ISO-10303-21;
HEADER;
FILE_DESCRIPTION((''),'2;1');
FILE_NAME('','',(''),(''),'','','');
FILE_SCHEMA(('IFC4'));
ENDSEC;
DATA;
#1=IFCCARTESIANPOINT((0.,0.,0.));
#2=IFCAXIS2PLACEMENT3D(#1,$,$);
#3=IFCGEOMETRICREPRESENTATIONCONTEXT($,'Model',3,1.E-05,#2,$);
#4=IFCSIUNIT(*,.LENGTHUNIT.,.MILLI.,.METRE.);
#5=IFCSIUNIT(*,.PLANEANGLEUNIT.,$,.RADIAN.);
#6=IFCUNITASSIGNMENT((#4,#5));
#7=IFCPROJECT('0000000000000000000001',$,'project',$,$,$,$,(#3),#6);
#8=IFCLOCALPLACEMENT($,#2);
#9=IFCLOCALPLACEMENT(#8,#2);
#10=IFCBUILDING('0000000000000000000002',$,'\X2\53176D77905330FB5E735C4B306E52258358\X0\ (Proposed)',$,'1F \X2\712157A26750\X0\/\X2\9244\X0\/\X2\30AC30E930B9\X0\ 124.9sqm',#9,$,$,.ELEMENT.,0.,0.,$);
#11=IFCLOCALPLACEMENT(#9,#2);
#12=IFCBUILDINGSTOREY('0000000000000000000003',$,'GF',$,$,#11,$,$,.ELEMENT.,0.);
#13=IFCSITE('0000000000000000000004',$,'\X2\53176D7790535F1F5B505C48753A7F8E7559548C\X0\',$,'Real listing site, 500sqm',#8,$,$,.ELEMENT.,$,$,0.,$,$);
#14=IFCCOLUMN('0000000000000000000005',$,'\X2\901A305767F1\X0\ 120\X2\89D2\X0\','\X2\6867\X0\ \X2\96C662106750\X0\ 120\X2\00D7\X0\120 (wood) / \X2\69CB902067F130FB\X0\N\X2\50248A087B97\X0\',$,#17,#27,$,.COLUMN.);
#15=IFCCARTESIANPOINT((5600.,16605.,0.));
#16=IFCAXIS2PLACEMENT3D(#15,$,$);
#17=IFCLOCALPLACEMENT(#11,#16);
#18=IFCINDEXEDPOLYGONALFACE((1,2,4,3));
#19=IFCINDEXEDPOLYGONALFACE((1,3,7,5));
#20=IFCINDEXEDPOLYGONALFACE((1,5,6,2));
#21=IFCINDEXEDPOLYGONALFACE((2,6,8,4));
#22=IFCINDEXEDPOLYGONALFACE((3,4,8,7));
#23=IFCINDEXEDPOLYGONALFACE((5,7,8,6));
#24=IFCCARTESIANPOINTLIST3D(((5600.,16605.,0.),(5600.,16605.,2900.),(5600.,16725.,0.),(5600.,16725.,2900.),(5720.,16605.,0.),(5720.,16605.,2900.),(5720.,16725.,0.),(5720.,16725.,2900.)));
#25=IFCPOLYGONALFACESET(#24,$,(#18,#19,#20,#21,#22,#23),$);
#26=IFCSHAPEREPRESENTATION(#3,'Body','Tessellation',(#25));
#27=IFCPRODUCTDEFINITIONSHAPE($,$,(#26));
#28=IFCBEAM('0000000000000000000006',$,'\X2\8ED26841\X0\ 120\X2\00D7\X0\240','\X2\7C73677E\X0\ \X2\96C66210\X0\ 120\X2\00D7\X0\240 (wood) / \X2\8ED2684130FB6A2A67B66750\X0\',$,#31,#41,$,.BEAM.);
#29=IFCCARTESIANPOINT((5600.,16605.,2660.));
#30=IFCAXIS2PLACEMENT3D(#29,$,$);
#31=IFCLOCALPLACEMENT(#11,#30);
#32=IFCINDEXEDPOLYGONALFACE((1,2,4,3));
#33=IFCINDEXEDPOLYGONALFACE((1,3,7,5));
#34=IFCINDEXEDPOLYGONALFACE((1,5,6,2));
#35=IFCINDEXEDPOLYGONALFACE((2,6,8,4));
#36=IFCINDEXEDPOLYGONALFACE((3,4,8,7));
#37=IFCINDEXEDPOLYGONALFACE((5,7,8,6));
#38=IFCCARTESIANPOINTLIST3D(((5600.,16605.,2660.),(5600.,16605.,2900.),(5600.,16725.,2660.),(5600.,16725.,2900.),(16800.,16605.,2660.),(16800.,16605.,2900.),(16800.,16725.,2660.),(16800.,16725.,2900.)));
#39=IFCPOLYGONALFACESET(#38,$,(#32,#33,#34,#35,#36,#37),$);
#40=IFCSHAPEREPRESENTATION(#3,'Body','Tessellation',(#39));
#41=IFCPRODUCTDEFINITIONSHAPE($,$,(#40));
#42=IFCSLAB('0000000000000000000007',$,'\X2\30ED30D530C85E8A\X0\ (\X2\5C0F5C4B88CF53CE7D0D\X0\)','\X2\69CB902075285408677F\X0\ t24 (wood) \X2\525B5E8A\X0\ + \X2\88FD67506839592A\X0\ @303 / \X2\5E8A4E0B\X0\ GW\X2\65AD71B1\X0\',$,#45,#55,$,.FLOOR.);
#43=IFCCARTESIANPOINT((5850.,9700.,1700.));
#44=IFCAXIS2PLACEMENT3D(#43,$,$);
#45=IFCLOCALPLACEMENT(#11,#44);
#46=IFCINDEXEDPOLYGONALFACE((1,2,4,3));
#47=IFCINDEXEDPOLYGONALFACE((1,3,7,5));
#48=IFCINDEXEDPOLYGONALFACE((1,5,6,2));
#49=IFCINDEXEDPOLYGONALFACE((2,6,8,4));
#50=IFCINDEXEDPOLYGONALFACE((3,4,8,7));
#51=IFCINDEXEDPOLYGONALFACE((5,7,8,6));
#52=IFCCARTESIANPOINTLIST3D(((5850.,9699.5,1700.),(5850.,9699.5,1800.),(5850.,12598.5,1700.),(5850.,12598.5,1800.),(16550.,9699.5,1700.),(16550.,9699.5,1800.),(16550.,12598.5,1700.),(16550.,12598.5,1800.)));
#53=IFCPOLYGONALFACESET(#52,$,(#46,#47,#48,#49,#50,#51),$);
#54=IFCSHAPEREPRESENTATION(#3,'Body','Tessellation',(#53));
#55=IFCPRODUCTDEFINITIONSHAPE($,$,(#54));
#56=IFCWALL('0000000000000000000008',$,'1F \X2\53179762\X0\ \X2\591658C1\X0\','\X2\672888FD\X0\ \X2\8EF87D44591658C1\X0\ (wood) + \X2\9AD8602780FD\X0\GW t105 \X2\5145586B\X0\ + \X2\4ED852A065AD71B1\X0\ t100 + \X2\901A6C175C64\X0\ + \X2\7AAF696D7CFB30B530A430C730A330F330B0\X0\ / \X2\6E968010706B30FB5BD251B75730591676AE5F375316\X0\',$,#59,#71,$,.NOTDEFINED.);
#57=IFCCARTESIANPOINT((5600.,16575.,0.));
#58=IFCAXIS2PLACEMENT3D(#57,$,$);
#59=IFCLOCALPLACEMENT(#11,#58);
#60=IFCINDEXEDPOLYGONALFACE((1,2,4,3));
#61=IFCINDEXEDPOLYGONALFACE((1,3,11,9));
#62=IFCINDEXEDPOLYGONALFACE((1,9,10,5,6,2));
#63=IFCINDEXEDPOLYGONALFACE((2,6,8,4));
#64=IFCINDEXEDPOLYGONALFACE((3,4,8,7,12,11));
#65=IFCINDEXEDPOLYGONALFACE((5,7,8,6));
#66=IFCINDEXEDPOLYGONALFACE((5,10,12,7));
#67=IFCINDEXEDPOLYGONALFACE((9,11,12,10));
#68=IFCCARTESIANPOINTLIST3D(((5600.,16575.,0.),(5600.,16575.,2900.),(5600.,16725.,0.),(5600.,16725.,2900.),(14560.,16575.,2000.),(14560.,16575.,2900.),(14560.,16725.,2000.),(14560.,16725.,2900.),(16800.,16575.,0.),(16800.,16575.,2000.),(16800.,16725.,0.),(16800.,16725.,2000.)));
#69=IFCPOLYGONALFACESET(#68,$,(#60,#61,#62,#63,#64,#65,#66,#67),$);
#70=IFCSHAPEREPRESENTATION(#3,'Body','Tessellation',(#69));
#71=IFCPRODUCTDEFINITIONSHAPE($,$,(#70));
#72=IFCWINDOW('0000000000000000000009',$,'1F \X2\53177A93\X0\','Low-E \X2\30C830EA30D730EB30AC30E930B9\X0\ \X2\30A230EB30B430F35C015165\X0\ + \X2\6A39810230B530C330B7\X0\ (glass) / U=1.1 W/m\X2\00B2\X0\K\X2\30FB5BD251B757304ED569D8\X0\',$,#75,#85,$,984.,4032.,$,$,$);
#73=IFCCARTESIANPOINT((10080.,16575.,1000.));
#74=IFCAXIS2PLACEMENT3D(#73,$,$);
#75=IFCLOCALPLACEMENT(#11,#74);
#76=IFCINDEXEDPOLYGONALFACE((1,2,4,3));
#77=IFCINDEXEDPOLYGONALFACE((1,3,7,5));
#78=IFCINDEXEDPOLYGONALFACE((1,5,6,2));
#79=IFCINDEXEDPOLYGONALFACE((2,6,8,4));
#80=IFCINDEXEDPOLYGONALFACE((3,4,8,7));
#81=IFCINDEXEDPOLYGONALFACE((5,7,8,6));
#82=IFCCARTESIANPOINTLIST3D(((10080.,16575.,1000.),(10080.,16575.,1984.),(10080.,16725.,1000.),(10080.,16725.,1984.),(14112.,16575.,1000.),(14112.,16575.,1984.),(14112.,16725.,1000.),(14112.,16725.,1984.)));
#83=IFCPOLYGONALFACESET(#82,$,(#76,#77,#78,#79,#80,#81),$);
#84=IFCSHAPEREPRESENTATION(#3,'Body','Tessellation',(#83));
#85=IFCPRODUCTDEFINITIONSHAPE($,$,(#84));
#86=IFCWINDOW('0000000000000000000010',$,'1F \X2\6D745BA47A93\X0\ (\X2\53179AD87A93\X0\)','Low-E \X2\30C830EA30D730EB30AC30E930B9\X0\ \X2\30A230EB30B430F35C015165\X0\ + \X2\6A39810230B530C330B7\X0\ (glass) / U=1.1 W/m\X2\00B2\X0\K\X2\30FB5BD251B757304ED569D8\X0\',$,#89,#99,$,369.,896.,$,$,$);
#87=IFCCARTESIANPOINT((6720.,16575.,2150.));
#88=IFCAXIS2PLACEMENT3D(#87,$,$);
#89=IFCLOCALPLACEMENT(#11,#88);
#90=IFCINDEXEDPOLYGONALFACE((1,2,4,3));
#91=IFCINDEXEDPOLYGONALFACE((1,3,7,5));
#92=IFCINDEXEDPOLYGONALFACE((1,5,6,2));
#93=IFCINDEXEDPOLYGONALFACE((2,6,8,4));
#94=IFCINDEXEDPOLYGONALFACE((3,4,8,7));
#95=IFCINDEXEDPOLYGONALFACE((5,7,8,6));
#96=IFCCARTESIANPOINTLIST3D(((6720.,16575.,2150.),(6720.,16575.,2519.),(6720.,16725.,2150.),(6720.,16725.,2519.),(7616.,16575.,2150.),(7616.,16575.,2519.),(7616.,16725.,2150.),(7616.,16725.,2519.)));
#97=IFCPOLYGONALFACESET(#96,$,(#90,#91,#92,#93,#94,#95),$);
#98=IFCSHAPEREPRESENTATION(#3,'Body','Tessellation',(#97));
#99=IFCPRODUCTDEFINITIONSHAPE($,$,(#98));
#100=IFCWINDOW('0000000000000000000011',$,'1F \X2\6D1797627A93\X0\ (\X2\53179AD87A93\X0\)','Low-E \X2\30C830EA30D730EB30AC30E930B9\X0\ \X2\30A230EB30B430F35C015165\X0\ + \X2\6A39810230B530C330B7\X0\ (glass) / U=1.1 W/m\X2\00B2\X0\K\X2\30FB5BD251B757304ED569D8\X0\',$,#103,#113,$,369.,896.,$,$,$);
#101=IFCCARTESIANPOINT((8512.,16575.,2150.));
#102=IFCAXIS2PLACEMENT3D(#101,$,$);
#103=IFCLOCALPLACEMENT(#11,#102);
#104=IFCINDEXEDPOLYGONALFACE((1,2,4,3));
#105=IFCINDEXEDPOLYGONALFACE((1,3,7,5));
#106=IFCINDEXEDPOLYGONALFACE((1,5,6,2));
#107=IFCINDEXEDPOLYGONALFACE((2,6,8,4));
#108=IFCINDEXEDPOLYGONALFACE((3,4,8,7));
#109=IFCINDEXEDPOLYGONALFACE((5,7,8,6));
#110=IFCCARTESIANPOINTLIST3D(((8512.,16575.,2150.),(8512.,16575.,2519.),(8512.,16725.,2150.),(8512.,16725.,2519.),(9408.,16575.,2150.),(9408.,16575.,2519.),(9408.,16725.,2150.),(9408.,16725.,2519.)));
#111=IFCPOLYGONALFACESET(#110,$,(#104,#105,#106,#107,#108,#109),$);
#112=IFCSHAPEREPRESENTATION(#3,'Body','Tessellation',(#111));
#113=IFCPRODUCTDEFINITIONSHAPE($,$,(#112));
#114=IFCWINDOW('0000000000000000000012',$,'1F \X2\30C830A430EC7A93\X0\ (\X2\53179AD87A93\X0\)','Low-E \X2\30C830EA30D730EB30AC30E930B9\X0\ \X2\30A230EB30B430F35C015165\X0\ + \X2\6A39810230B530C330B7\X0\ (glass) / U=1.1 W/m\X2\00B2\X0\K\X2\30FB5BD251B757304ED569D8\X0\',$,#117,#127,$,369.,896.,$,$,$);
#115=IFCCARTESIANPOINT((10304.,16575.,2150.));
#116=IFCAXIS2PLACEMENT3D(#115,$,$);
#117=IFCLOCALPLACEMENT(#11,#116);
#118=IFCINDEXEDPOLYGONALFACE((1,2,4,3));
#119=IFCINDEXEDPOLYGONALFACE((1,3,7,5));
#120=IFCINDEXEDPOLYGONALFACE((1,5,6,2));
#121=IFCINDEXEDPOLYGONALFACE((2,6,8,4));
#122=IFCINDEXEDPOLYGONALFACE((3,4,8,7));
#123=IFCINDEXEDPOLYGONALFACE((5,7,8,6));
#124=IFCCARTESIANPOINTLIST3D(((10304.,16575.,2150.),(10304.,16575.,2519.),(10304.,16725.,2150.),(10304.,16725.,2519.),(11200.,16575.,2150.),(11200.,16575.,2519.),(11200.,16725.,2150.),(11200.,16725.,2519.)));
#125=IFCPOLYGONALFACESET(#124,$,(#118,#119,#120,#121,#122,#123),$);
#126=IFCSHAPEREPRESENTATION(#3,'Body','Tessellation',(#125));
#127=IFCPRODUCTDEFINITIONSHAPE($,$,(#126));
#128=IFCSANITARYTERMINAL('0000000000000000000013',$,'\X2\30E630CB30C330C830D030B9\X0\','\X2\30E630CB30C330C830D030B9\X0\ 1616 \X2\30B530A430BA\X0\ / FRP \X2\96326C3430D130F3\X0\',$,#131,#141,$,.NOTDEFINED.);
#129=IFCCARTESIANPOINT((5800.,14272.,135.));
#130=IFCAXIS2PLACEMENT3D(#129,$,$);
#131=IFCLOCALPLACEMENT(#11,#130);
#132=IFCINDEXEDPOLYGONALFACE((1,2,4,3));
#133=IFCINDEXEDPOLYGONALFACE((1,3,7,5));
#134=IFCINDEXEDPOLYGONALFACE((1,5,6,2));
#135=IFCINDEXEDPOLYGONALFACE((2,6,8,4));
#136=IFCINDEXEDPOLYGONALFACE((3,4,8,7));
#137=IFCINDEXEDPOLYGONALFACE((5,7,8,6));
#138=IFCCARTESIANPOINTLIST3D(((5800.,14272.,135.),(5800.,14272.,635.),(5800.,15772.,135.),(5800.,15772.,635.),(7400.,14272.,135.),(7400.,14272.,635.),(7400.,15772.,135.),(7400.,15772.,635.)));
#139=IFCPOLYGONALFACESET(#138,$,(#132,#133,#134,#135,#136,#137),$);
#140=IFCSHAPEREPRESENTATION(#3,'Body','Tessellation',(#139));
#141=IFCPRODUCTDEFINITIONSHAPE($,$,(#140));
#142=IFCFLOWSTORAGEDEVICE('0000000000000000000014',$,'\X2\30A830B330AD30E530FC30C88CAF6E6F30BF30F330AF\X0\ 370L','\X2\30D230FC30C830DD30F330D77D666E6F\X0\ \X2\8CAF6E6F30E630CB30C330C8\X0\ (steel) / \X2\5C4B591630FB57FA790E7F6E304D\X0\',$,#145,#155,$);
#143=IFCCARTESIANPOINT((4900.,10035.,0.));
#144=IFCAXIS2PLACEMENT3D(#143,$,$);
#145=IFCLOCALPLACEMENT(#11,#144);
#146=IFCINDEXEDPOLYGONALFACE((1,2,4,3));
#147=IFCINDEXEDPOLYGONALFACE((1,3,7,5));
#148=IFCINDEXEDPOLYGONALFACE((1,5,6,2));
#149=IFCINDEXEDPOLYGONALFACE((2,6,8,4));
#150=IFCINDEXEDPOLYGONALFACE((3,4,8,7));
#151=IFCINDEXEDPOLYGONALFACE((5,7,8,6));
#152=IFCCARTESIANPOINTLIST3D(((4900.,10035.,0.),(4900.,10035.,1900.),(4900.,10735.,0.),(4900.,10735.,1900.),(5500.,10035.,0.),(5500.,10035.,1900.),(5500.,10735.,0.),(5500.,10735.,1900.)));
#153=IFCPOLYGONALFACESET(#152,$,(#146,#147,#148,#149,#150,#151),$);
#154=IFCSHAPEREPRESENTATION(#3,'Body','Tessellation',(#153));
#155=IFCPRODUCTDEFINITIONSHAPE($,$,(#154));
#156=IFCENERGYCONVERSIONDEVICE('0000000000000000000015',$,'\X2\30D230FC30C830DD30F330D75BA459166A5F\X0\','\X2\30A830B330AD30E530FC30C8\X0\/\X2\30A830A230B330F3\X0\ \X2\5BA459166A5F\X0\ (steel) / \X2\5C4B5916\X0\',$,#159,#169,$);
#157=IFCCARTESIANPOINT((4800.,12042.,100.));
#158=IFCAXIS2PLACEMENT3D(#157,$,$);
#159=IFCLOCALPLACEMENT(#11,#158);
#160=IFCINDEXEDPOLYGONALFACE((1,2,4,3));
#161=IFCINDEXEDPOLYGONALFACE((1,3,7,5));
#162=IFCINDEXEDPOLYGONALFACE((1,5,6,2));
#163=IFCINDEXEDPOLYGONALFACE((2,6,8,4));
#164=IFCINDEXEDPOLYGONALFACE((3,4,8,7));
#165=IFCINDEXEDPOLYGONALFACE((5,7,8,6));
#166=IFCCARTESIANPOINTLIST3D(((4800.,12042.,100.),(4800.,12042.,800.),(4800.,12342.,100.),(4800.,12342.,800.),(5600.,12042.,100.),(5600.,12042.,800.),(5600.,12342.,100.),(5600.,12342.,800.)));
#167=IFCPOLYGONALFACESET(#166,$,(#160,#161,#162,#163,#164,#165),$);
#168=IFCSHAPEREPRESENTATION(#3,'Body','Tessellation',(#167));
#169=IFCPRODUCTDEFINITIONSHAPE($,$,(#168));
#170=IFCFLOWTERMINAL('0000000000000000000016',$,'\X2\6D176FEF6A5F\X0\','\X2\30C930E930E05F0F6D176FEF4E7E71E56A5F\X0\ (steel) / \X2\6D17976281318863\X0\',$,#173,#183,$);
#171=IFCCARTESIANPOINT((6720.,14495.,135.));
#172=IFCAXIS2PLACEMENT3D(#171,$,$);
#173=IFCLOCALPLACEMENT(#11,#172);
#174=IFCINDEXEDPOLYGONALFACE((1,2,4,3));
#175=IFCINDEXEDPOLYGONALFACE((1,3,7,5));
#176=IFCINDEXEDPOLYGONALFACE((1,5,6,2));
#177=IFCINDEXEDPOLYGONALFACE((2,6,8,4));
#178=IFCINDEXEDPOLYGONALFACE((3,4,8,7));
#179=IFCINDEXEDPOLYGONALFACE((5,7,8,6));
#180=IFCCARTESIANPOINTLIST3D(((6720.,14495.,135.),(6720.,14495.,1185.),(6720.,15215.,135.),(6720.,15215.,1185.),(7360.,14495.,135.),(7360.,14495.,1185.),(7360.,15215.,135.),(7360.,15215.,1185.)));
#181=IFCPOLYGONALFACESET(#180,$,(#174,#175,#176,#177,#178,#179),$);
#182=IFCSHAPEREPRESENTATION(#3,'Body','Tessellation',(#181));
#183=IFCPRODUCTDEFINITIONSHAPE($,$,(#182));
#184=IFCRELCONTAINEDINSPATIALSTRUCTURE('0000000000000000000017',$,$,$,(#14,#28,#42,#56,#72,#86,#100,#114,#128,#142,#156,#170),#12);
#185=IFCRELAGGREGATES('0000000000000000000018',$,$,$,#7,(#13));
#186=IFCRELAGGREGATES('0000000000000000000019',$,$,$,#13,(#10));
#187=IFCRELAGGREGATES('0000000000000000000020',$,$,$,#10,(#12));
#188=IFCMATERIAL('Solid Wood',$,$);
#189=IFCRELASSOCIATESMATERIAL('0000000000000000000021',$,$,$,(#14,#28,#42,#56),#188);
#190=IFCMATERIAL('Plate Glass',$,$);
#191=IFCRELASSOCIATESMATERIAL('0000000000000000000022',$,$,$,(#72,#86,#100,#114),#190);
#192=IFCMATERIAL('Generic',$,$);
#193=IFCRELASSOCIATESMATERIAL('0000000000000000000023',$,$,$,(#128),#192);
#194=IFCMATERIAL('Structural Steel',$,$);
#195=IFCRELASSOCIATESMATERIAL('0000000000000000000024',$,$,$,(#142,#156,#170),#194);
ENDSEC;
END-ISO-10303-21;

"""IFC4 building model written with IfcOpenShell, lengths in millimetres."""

from ifc_helpers import new_model, si_unit, frame, frame_2d, origin, place, context, project, spatial, rectangle, extrude, material, element, fill, save


model = new_model("IFC4")

# Units and contexts
model_context = context("Model", 3, precision=1e-05, world=origin())
ifc_project = project(units=[si_unit("LENGTHUNIT", "METRE", prefix="MILLI"), si_unit("PLANEANGLEUNIT", "RADIAN")], contexts=[model_context])

# Site, building, storey
site_placement = place(None, origin())
site = spatial("IfcSite", under=ifc_project, at=site_placement, Name="北海道弟子屈町美留和", ObjectType="Real listing site, 500sqm", CompositionType="ELEMENT", RefElevation=0.0)
building_placement = place(site_placement, origin())
building = spatial("IfcBuilding", under=site, at=building_placement, Name="北海道・平屋の別荘 (Proposed)", ObjectType="1F 無垢材/鉄/ガラス 124.9sqm", CompositionType="ELEMENT", ElevationOfRefHeight=0.0, ElevationOfTerrain=0.0)
storey_placement = place(building_placement, origin())
storey = spatial("IfcBuildingStorey", under=building, at=storey_placement, Name="GF", CompositionType="ELEMENT", Elevation=0.0)

# Column
ifc_material_1 = material(Name="Solid Wood")
column_1_placement = place(storey_placement, frame((5600.0, 16605.0, 0.0)))
element("IfcColumn", 1, at=column_1_placement, inside=storey, material=ifc_material_1, Name="通し柱 120角", Description="桧 集成材 120×120 (wood) / 構造柱・N値計算", PredefinedType="COLUMN", context=model_context, shape_type="SweptSolid", body=[
    extrude(rectangle(XDim=120.0, YDim=120.0, at=frame_2d((60.0, 60.0))), frame((5600.0, 16605.0, 0.0)), (0.0, 0.0, 1.0), 2900.0),
])

# Beam
beam_1_placement = place(storey_placement, frame((5600.0, 16605.0, 2660.0)))
element("IfcBeam", 2, at=beam_1_placement, inside=storey, material=ifc_material_1, Name="軒桁 120×240", Description="米松 集成 120×240 (wood) / 軒桁・横架材", PredefinedType="BEAM", context=model_context, shape_type="SweptSolid", body=[
    extrude(rectangle(XDim=11200.0, YDim=120.0, at=frame_2d((5600.0, 60.0))), frame((5600.0, 16605.0, 2660.0)), (0.0, 0.0, 1.0), 240.0),
])

# Slab
slab_placement = place(storey_placement, frame((5850.0, 9700.0, 1700.0)))
element("IfcSlab", 3, at=slab_placement, inside=storey, material=ifc_material_1, Name="ロフト床 (小屋裏収納)", Description="構造用合板 t24 (wood) 剛床 + 製材根太 @303 / 床下 GW断熱", PredefinedType="FLOOR", context=model_context, shape_type="SweptSolid", body=[
    extrude(rectangle(XDim=10700.0, YDim=2899.0, at=frame_2d((5350.0, 1449.0))), frame((5850.0, 9700.0, 1700.0)), (0.0, 0.0, 1.0), 100.0),
])

# Wall, openings, windows
wall_1_placement = place(storey_placement, frame((5600.0, 16575.0, 0.0)))
wall_1 = element("IfcWall", 4, at=wall_1_placement, inside=storey, material=ifc_material_1, Name="1F 北面 外壁", Description="木製 軸組外壁 (wood) + 高性能GW t105 充填 + 付加断熱 t100 + 通気層 + 窯業系サイディング / 準耐火・寒冷地外皮強化", PredefinedType="NOTDEFINED", context=model_context, shape_type="SweptSolid", body=[
    extrude(rectangle(XDim=11200.0, YDim=150.0, at=frame_2d((5600.0, 75.0))), frame((5600.0, 16575.0, 0.0)), (0.0, 0.0, 1.0), 2900.0),
])
opening_1_placement = place(storey_placement, frame((10080.0, 16575.0, 1000.0)))
opening_1 = element("IfcOpeningElement", 5, at=opening_1_placement, cuts=wall_1, PredefinedType="NOTDEFINED", context=model_context, shape_type="SweptSolid", body=[
    extrude(rectangle(XDim=4032.0, YDim=150.0, at=frame_2d((2016.0, 75.0))), frame((10080.0, 16575.0, 1000.0)), (0.0, 0.0, 1.0), 984.0),
])
opening_2_placement = place(storey_placement, frame((6720.0, 16575.0, 2150.0)))
opening_2 = element("IfcOpeningElement", 6, at=opening_2_placement, cuts=wall_1, PredefinedType="NOTDEFINED", context=model_context, shape_type="SweptSolid", body=[
    extrude(rectangle(XDim=896.0, YDim=150.0, at=frame_2d((448.0, 75.0))), frame((6720.0, 16575.0, 2150.0)), (0.0, 0.0, 1.0), 369.0),
])
opening_3_placement = place(storey_placement, frame((8512.0, 16575.0, 2150.0)))
opening_3 = element("IfcOpeningElement", 7, at=opening_3_placement, cuts=wall_1, PredefinedType="NOTDEFINED", context=model_context, shape_type="SweptSolid", body=[
    extrude(rectangle(XDim=896.0, YDim=150.0, at=frame_2d((448.0, 75.0))), frame((8512.0, 16575.0, 2150.0)), (0.0, 0.0, 1.0), 369.0),
])
opening_4_placement = place(storey_placement, frame((10304.0, 16575.0, 2150.0)))
opening_4 = element("IfcOpeningElement", 8, at=opening_4_placement, cuts=wall_1, PredefinedType="NOTDEFINED", context=model_context, shape_type="SweptSolid", body=[
    extrude(rectangle(XDim=896.0, YDim=150.0, at=frame_2d((448.0, 75.0))), frame((10304.0, 16575.0, 2150.0)), (0.0, 0.0, 1.0), 369.0),
])
ifc_material_2 = material(Name="Plate Glass")
window_1_placement = place(storey_placement, frame((10080.0, 16575.0, 1000.0)))
window_1 = element("IfcWindow", 9, at=window_1_placement, inside=storey, material=ifc_material_2, Name="1F 北窓", Description="Low-E トリプルガラス アルゴン封入 + 樹脂サッシ (glass) / U=1.1 W/m²K・寒冷地仕様", OverallHeight=984.0, OverallWidth=4032.0, context=model_context, shape_type="SweptSolid", body=[
    extrude(rectangle(XDim=4032.0, YDim=150.0, at=frame_2d((2016.0, 75.0))), frame((10080.0, 16575.0, 1000.0)), (0.0, 0.0, 1.0), 984.0),
])
fill(opening_1, window_1)
window_2_placement = place(storey_placement, frame((6720.0, 16575.0, 2150.0)))
window_2 = element("IfcWindow", 10, at=window_2_placement, inside=storey, material=ifc_material_2, Name="1F 浴室窓 (北高窓)", Description="Low-E トリプルガラス アルゴン封入 + 樹脂サッシ (glass) / U=1.1 W/m²K・寒冷地仕様", OverallHeight=369.0, OverallWidth=896.0, context=model_context, shape_type="SweptSolid", body=[
    extrude(rectangle(XDim=896.0, YDim=150.0, at=frame_2d((448.0, 75.0))), frame((6720.0, 16575.0, 2150.0)), (0.0, 0.0, 1.0), 369.0),
])
fill(opening_2, window_2)
window_3_placement = place(storey_placement, frame((8512.0, 16575.0, 2150.0)))
window_3 = element("IfcWindow", 11, at=window_3_placement, inside=storey, material=ifc_material_2, Name="1F 洗面窓 (北高窓)", Description="Low-E トリプルガラス アルゴン封入 + 樹脂サッシ (glass) / U=1.1 W/m²K・寒冷地仕様", OverallHeight=369.0, OverallWidth=896.0, context=model_context, shape_type="SweptSolid", body=[
    extrude(rectangle(XDim=896.0, YDim=150.0, at=frame_2d((448.0, 75.0))), frame((8512.0, 16575.0, 2150.0)), (0.0, 0.0, 1.0), 369.0),
])
fill(opening_3, window_3)
window_4_placement = place(storey_placement, frame((10304.0, 16575.0, 2150.0)))
window_4 = element("IfcWindow", 12, at=window_4_placement, inside=storey, material=ifc_material_2, Name="1F トイレ窓 (北高窓)", Description="Low-E トリプルガラス アルゴン封入 + 樹脂サッシ (glass) / U=1.1 W/m²K・寒冷地仕様", OverallHeight=369.0, OverallWidth=896.0, context=model_context, shape_type="SweptSolid", body=[
    extrude(rectangle(XDim=896.0, YDim=150.0, at=frame_2d((448.0, 75.0))), frame((10304.0, 16575.0, 2150.0)), (0.0, 0.0, 1.0), 369.0),
])
fill(opening_4, window_4)

# Sanitary terminal
ifc_material_3 = material(Name="Generic")
sanitary_terminal_placement = place(storey_placement, frame((5800.0, 14272.0, 135.0)))
element("IfcSanitaryTerminal", 13, at=sanitary_terminal_placement, inside=storey, material=ifc_material_3, Name="ユニットバス", Description="ユニットバス 1616 サイズ / FRP 防水パン", PredefinedType="NOTDEFINED", context=model_context, shape_type="SweptSolid", body=[
    extrude(rectangle(XDim=1600.0, YDim=1500.0, at=frame_2d((800.0, 750.0))), frame((5800.0, 14272.0, 135.0)), (0.0, 0.0, 1.0), 500.0),
])

# Flow storage device
ifc_material_4 = material(Name="Structural Steel")
flow_storage_device_placement = place(storey_placement, frame((4900.0, 10035.0, 0.0)))
element("IfcFlowStorageDevice", 14, at=flow_storage_device_placement, inside=storey, material=ifc_material_4, Name="エコキュート貯湯タンク 370L", Description="ヒートポンプ給湯 貯湯ユニット (steel) / 屋外・基礎置き", context=model_context, shape_type="SweptSolid", body=[
    extrude(rectangle(XDim=600.0, YDim=700.0, at=frame_2d((300.0, 350.0))), frame((4900.0, 10035.0, 0.0)), (0.0, 0.0, 1.0), 1900.0),
])

# Energy conversion device
energy_conversion_device_placement = place(storey_placement, frame((4800.0, 12042.0, 100.0)))
element("IfcEnergyConversionDevice", 15, at=energy_conversion_device_placement, inside=storey, material=ifc_material_4, Name="ヒートポンプ室外機", Description="エコキュート/エアコン 室外機 (steel) / 屋外", context=model_context, shape_type="SweptSolid", body=[
    extrude(rectangle(XDim=800.0, YDim=300.0, at=frame_2d((400.0, 150.0))), frame((4800.0, 12042.0, 100.0)), (0.0, 0.0, 1.0), 700.0),
])

# Flow terminal
flow_terminal_placement = place(storey_placement, frame((6720.0, 14495.0, 135.0)))
element("IfcFlowTerminal", 16, at=flow_terminal_placement, inside=storey, material=ifc_material_4, Name="洗濯機", Description="ドラム式洗濯乾燥機 (steel) / 洗面脱衣", context=model_context, shape_type="SweptSolid", body=[
    extrude(rectangle(XDim=640.0, YDim=720.0, at=frame_2d((320.0, 360.0))), frame((6720.0, 14495.0, 135.0)), (0.0, 0.0, 1.0), 1050.0),
])

save(model, "model.ifc")
